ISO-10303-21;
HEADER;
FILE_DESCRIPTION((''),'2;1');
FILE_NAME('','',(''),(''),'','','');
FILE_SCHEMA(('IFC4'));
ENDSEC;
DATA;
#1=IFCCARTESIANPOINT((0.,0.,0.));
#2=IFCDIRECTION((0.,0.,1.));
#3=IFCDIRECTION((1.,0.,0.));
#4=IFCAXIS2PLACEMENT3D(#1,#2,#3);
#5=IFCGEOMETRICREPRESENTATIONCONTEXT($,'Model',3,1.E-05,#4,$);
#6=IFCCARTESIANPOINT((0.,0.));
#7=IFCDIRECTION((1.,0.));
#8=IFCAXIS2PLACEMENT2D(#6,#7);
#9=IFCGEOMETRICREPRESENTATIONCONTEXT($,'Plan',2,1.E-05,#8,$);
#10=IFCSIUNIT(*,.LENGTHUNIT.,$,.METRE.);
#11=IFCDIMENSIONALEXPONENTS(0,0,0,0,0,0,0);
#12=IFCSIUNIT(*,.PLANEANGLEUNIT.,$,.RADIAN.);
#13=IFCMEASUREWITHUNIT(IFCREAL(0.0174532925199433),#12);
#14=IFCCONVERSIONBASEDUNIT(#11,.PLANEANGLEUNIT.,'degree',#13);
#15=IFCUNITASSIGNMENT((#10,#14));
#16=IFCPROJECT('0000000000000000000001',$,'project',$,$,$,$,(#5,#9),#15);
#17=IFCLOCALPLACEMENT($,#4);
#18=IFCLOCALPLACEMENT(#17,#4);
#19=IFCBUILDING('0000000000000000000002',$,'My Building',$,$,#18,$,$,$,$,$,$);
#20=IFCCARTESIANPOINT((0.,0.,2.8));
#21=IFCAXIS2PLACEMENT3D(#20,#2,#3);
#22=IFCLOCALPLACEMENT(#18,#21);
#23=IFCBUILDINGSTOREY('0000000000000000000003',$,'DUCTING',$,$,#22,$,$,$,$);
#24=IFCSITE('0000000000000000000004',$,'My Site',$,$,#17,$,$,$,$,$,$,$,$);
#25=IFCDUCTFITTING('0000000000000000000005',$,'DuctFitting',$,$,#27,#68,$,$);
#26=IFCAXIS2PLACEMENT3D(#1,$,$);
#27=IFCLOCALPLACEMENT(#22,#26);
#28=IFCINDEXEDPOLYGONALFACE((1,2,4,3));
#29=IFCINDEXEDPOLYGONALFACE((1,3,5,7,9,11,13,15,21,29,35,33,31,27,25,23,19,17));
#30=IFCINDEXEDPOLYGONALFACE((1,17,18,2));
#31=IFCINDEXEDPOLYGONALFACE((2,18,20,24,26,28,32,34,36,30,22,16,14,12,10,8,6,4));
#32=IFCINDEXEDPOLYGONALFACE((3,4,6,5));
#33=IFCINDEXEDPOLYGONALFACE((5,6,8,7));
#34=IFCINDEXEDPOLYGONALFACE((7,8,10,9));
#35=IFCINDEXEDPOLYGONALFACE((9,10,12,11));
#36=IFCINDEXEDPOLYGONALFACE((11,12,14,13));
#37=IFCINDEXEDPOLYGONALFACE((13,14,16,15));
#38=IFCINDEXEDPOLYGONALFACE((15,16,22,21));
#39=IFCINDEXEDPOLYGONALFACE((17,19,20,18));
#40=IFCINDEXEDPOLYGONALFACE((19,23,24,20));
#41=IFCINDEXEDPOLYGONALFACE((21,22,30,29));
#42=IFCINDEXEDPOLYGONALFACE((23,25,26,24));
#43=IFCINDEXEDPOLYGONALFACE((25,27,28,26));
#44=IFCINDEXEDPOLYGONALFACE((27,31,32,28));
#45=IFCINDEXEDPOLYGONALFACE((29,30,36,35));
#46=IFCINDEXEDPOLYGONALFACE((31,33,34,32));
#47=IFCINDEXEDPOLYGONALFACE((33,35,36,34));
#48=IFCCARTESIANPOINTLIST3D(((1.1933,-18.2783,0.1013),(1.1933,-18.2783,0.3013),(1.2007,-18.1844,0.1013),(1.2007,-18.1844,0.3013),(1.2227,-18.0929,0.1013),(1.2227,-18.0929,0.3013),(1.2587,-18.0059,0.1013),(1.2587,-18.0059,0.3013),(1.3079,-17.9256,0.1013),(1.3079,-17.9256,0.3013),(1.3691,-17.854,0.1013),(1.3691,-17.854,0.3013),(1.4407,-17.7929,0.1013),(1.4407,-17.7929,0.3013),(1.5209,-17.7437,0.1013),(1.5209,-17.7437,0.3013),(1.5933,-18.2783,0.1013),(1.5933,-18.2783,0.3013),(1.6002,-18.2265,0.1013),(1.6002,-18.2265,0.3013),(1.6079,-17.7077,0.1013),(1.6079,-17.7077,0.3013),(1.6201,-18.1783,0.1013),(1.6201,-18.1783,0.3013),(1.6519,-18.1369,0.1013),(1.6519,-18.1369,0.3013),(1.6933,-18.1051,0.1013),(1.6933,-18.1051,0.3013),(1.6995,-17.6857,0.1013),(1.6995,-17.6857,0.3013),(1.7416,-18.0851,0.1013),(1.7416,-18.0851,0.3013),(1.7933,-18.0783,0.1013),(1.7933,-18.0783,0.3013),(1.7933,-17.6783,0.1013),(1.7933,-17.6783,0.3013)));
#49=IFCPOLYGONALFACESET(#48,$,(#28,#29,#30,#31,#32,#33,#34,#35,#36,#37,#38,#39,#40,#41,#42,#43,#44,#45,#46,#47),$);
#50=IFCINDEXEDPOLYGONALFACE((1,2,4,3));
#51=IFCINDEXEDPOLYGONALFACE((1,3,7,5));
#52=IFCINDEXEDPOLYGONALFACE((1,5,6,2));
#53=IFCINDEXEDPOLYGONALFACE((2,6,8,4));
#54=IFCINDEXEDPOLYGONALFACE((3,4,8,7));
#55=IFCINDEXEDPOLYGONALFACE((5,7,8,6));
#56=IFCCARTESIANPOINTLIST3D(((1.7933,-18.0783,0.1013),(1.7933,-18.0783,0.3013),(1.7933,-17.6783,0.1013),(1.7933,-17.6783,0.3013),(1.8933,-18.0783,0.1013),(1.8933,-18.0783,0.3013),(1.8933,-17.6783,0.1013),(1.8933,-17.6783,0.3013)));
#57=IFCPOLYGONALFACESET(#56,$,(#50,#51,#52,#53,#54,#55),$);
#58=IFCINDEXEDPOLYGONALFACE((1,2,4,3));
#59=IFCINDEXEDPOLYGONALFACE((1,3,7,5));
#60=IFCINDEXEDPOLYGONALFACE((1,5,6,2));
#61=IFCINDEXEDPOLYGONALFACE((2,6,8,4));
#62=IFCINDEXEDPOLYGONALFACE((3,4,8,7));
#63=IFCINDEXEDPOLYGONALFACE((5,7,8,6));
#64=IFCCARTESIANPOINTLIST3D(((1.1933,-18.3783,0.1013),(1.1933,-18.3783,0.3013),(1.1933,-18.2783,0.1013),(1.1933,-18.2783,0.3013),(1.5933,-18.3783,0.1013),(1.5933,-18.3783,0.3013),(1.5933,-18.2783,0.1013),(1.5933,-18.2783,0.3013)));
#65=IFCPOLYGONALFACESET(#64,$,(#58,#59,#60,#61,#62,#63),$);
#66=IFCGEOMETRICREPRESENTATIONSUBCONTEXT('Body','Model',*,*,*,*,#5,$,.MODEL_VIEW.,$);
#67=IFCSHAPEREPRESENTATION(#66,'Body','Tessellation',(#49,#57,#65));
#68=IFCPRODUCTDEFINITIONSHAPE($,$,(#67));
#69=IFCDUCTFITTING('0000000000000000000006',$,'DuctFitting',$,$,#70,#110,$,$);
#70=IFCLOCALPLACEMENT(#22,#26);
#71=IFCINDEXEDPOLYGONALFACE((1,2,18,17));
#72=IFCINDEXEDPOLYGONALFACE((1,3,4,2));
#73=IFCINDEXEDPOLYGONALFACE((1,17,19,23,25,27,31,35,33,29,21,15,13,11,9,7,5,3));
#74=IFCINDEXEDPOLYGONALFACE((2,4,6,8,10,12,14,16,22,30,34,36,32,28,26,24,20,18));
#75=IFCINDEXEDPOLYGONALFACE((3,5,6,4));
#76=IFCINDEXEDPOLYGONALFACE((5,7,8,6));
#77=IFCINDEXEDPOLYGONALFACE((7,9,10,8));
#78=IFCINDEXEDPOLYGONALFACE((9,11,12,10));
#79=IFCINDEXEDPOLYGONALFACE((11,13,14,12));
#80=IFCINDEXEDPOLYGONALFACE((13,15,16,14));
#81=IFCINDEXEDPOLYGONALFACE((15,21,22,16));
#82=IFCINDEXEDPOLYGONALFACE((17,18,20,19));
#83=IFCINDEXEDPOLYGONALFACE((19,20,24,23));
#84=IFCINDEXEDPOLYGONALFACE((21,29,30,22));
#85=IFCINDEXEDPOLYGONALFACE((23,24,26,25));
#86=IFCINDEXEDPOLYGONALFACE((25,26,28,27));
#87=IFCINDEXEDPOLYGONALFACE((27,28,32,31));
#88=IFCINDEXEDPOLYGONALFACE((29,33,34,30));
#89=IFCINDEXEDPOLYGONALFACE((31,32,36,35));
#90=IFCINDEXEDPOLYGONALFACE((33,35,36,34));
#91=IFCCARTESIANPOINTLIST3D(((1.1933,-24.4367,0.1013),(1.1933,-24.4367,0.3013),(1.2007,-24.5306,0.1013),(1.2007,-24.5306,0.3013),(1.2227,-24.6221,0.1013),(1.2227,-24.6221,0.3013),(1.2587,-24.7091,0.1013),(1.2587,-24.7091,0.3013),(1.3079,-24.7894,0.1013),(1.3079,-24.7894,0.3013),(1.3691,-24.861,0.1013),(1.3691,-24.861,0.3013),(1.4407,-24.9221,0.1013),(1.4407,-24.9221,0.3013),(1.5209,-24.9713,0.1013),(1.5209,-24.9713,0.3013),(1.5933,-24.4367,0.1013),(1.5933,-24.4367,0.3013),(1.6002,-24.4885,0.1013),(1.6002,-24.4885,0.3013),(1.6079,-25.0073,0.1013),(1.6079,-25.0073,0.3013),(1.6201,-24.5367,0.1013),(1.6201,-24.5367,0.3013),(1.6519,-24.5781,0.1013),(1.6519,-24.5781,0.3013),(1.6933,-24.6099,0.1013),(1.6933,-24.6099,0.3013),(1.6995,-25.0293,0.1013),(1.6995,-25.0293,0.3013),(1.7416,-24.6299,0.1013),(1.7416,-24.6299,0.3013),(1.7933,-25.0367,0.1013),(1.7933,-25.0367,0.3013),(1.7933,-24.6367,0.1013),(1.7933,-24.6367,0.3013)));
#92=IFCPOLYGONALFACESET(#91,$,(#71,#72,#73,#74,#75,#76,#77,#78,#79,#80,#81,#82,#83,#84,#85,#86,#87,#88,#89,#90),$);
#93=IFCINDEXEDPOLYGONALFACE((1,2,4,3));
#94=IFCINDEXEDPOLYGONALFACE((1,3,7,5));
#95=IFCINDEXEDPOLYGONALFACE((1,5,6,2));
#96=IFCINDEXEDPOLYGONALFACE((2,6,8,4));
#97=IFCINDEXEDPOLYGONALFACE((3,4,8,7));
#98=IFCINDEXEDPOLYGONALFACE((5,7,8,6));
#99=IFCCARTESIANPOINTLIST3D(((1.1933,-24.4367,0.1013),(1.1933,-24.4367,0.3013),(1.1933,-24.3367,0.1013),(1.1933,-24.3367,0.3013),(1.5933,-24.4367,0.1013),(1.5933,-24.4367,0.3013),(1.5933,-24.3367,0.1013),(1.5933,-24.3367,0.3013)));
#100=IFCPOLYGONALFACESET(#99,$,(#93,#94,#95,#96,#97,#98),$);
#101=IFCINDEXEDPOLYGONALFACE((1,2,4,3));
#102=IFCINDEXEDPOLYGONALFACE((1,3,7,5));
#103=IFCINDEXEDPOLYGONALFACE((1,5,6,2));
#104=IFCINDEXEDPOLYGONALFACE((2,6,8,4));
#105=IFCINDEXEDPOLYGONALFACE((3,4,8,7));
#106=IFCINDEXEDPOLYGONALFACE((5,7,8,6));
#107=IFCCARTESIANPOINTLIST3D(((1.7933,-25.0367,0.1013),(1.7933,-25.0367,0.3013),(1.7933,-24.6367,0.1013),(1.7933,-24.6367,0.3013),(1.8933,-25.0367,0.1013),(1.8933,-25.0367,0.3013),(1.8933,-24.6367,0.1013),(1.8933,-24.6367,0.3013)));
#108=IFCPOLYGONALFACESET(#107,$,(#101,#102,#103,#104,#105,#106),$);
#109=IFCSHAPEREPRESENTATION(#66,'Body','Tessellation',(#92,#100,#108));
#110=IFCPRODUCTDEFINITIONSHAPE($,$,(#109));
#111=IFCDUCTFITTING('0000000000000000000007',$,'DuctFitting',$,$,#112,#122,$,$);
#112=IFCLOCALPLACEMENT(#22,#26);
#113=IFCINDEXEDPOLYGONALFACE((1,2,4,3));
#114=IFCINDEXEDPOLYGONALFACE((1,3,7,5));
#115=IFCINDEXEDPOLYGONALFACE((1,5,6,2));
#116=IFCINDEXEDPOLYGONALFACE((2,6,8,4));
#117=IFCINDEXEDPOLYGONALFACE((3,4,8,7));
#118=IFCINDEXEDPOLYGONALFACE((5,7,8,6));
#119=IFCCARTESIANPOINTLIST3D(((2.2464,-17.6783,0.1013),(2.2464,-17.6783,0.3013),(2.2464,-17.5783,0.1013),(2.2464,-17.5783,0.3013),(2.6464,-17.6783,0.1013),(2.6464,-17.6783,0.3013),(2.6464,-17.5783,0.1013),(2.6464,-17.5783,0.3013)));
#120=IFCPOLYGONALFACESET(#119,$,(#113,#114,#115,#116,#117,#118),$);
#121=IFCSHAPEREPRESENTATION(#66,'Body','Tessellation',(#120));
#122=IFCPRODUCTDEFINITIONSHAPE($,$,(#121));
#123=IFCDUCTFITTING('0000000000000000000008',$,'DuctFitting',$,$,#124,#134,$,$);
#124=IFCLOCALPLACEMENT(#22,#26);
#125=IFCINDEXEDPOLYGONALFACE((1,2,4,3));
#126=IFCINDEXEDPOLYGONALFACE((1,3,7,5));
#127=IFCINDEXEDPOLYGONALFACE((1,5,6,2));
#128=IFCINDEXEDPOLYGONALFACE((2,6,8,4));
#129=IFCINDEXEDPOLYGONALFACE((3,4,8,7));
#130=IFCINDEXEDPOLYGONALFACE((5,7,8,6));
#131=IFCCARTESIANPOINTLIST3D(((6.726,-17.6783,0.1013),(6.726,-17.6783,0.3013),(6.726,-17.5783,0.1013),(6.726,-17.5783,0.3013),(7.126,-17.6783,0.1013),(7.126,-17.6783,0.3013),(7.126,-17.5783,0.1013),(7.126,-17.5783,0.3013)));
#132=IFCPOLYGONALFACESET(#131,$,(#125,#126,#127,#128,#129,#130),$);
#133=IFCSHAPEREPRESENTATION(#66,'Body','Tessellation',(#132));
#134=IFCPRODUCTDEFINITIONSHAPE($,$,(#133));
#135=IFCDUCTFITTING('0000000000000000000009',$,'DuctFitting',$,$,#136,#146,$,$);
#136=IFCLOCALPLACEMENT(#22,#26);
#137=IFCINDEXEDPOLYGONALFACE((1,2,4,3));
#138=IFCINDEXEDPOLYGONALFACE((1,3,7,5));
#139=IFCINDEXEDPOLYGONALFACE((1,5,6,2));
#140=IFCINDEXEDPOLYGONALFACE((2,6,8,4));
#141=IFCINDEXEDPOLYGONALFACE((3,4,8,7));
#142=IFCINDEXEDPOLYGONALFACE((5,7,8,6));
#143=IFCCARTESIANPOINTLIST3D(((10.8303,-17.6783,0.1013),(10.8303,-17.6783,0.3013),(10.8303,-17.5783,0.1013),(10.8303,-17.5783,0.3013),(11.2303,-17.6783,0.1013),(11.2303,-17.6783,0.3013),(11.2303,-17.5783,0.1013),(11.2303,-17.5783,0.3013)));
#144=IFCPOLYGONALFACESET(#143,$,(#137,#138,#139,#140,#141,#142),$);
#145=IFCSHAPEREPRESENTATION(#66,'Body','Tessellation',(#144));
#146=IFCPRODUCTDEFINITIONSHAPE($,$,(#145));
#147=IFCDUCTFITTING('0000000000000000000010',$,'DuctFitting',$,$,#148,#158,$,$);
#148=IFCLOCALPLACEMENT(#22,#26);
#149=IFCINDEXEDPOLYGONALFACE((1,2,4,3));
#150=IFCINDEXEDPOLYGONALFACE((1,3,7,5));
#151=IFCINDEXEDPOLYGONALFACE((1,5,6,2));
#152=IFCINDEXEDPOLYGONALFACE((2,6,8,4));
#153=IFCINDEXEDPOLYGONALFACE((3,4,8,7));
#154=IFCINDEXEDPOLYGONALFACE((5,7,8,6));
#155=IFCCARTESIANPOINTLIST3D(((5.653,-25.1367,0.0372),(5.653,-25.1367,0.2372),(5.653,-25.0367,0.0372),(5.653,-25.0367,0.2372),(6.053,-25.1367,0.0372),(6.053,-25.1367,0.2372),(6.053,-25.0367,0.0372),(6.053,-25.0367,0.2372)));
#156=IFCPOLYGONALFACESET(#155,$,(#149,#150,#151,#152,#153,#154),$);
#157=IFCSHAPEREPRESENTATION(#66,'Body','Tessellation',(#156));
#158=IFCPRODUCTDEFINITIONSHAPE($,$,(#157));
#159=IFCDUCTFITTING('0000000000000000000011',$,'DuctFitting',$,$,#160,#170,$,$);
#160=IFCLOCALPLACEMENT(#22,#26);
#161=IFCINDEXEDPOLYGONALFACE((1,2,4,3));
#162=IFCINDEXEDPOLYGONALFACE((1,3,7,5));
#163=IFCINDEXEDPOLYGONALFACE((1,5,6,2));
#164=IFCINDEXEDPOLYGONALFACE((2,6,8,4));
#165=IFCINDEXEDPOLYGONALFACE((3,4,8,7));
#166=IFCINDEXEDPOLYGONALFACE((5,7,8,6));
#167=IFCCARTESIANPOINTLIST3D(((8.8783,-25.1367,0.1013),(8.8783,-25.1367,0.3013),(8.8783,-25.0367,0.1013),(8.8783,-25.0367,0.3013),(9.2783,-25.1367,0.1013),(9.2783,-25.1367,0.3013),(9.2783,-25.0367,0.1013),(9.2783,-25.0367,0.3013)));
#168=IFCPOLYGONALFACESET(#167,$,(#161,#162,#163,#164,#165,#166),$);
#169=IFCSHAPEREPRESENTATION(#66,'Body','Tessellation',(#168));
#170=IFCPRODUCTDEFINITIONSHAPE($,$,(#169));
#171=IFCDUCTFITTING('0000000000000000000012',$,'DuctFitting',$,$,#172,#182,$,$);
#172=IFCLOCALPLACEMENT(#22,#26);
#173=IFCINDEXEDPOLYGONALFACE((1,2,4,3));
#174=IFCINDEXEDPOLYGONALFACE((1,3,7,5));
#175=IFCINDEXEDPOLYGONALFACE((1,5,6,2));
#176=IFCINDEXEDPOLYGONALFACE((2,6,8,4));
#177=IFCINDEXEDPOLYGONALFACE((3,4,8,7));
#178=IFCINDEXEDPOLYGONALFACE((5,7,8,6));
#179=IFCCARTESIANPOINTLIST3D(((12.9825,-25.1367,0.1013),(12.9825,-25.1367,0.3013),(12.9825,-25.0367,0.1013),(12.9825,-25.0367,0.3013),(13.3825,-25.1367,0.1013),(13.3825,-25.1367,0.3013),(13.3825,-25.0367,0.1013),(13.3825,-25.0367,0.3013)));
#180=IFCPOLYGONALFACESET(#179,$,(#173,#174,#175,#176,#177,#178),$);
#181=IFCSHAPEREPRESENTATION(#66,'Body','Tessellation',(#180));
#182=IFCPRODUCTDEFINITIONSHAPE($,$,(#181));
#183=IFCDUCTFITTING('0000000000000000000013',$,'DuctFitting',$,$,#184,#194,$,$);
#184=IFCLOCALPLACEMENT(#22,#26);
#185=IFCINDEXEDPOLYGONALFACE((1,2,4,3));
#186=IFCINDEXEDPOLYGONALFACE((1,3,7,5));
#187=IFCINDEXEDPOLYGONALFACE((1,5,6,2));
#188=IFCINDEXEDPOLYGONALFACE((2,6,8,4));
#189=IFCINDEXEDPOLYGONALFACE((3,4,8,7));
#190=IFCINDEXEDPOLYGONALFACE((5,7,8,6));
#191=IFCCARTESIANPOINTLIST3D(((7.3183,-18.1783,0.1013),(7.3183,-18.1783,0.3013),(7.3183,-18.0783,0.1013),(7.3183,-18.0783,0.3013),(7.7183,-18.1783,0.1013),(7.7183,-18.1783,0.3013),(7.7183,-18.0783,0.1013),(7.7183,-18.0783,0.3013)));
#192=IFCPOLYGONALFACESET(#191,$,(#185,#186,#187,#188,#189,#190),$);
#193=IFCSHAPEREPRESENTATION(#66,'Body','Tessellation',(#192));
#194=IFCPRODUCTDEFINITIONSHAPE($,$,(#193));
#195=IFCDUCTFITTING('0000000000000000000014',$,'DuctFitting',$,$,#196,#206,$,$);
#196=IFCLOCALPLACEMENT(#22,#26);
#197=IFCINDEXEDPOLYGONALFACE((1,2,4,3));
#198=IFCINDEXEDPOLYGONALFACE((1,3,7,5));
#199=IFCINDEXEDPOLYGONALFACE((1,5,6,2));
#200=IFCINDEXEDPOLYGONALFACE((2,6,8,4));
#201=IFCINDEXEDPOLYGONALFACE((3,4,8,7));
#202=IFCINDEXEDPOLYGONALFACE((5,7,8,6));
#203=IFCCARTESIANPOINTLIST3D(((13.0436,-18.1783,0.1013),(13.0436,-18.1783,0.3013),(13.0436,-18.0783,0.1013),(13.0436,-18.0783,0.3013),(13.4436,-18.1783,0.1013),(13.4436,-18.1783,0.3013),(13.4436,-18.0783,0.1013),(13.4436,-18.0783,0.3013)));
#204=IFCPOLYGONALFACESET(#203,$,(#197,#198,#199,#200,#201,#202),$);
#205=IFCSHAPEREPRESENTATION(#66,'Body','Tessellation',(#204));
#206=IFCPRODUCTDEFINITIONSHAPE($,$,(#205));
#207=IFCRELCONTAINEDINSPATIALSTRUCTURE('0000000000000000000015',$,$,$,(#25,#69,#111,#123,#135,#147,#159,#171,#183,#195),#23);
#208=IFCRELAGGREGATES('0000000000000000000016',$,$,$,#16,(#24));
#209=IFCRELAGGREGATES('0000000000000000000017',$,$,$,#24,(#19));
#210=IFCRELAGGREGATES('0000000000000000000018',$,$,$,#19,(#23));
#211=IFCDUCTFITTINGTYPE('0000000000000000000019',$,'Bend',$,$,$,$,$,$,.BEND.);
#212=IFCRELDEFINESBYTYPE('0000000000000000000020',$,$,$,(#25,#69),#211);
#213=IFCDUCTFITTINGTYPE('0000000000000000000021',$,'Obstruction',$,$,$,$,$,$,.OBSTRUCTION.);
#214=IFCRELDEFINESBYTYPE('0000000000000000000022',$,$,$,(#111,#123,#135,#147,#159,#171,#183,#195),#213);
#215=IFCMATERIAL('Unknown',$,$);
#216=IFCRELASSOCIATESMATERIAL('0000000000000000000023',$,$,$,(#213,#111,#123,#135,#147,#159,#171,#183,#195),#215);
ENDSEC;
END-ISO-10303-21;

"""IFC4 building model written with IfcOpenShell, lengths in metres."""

from ifc_helpers import new_model, entity, si_unit, converted_unit, frame, origin_with_axes, origin_2d_with_axis, place, context, subcontext, project, spatial, line, arc, indexed_curve, rectangle, outline, extrude, source, transform, mapped, material, material_profile, profile_set, profile_usage, type_object, type_shapes, element, save


model = new_model("IFC4")

# Units and contexts
model_context = context("Model", 3, precision=1e-05, world=origin_with_axes())
plan_context = context("Plan", 2, precision=1e-05, world=origin_2d_with_axis())
body_context = subcontext(model_context, "Body", "Model", "MODEL_VIEW")
ifc_project = project(units=[si_unit("LENGTHUNIT", "METRE"), converted_unit("PLANEANGLEUNIT", "degree", entity("IfcReal", 0.0174532925199433), si_unit("PLANEANGLEUNIT", "RADIAN"), dimensions=[0, 0, 0, 0, 0, 0, 0])], contexts=[model_context, plan_context])

# Site, building, storey
site_placement = place(None, origin_with_axes())
site = spatial("IfcSite", under=ifc_project, at=site_placement, Name="My Site")
building_placement = place(site_placement, origin_with_axes())
building = spatial("IfcBuilding", under=site, at=building_placement, Name="My Building")
storey_placement = place(building_placement, frame((0.0, 0.0, 2.8), z_axis=(0.0, 0.0, 1.0), x_axis=(1.0, 0.0, 0.0)))
storey = spatial("IfcBuildingStorey", under=building, at=storey_placement, Name="DUCTING")

# Shared definitions
ifc_material = material(Name="Unknown")

# Duct fittings
duct_fitting_type_1 = type_object("IfcDuctFittingType", Name="Bend", PredefinedType="BEND")
shared_shape = source(origin_with_axes(), body_context, "Body", "SweptSolid", [
    extrude(outline(indexed_curve([(-0.2, 0.0), (-0.2586, -0.1414), (-0.4, -0.2), (-0.4, -0.6), (0.0243, -0.4243), (0.2, 0.0)], segments=[arc(1, 2, 3), line(3, 4), arc(4, 5, 6), line(6, 1)])), frame((0.0, -0.1, -0.1), z_axis=(0.0, -1.0, 0.0), x_axis=(1.0, 0.0, 0.0)), (0.0, 0.0, -1.0), 0.2),
    extrude(rectangle(XDim=0.4, YDim=0.2), origin_with_axes(), (0.0, 0.0, -1.0), 0.1),
    extrude(rectangle(XDim=0.4, YDim=0.2), frame((-0.4, 0.0, -0.5), z_axis=(-1.0, 0.0, 0.000001), x_axis=(-0.000001, 0.0, -1.0)), (0.0, 0.0, 1.0), 0.1),
])
type_shapes(duct_fitting_type_1, [shared_shape])
for number, where, z_axis, x_axis, name in (
    (1, (1.8933, -17.8783, 0.2013), (1.0, -0.000001, 0.000001), (0.000001, 1.0, 0.0), "DuctFitting"),
    (2, (1.3933, -24.3367, 0.2013), (0.0, 1.0, 0.0), (-1.0, 0.0, 0.0), "DuctFitting"),
):
    element("IfcDuctFitting", number, at=place(storey_placement, frame(where, z_axis=z_axis, x_axis=x_axis)), inside=storey, type_object=duct_fitting_type_1, Name=name, context=body_context, shape_type="MappedRepresentation", body=[
        mapped(shared_shape, transform((0.0, 0.0, 0.0), x_axis=(1.0, 0.0, 0.0), y_axis=(0.0, 1.0, 0.0), z_axis=(0.0, 0.0, 1.0), scale=1.0)),
    ])
ifc_material_profile_1 = material_profile(ifc_material, rectangle(XDim=0.4, YDim=0.2))
ifc_profile_set_1 = profile_set([ifc_material_profile_1])
ifc_profile_usage_1 = profile_usage(ifc_profile_set_1, cardinal=5)
duct_fitting_type_2 = type_object("IfcDuctFittingType", Name="Obstruction", PredefinedType="OBSTRUCTION", material=ifc_profile_set_1)
duct_fitting_1_placement = place(storey_placement, frame((2.4464, -17.6783, 0.2013), z_axis=(0.0, 1.0, 0.0), x_axis=(-1.0, 0.0, 0.0)))
element("IfcDuctFitting", 3, at=duct_fitting_1_placement, inside=storey, type_object=duct_fitting_type_2, material=ifc_profile_usage_1, Name="DuctFitting", context=body_context, shape_type="SweptSolid", body=[
    extrude(rectangle(XDim=0.4, YDim=0.2), origin_with_axes(), (0.0, 0.0, 1.0), 0.1),
])
ifc_profile_usage_2 = profile_usage(ifc_profile_set_1, cardinal=5)
duct_fitting_2_placement = place(storey_placement, frame((6.926, -17.6783, 0.2013), z_axis=(0.0, 1.0, 0.0), x_axis=(-1.0, 0.0, 0.0)))
element("IfcDuctFitting", 4, at=duct_fitting_2_placement, inside=storey, type_object=duct_fitting_type_2, material=ifc_profile_usage_2, Name="DuctFitting", context=body_context, shape_type="SweptSolid", body=[
    extrude(rectangle(XDim=0.4, YDim=0.2), origin_with_axes(), (0.0, 0.0, 1.0), 0.1),
])
ifc_profile_usage_3 = profile_usage(ifc_profile_set_1, cardinal=5)
duct_fitting_3_placement = place(storey_placement, frame((11.0303, -17.6783, 0.2013), z_axis=(0.0, 1.0, 0.0), x_axis=(-1.0, 0.0, 0.0)))
element("IfcDuctFitting", 5, at=duct_fitting_3_placement, inside=storey, type_object=duct_fitting_type_2, material=ifc_profile_usage_3, Name="DuctFitting", context=body_context, shape_type="SweptSolid", body=[
    extrude(rectangle(XDim=0.4, YDim=0.2), origin_with_axes(), (0.0, 0.0, 1.0), 0.1),
])
ifc_profile_usage_4 = profile_usage(ifc_profile_set_1, cardinal=5)
duct_fitting_4_placement = place(storey_placement, frame((5.853, -25.0367, 0.1372), z_axis=(0.0, -1.0, 0.0), x_axis=(1.0, 0.0, 0.0)))
element("IfcDuctFitting", 6, at=duct_fitting_4_placement, inside=storey, type_object=duct_fitting_type_2, material=ifc_profile_usage_4, Name="DuctFitting", context=body_context, shape_type="SweptSolid", body=[
    extrude(rectangle(XDim=0.4, YDim=0.2), origin_with_axes(), (0.0, 0.0, 1.0), 0.1),
])
ifc_profile_usage_5 = profile_usage(ifc_profile_set_1, cardinal=5)
duct_fitting_5_placement = place(storey_placement, frame((9.0783, -25.0367, 0.2013), z_axis=(0.0, -1.0, 0.0), x_axis=(1.0, 0.0, 0.0)))
element("IfcDuctFitting", 7, at=duct_fitting_5_placement, inside=storey, type_object=duct_fitting_type_2, material=ifc_profile_usage_5, Name="DuctFitting", context=body_context, shape_type="SweptSolid", body=[
    extrude(rectangle(XDim=0.4, YDim=0.2), origin_with_axes(), (0.0, 0.0, 1.0), 0.1),
])
ifc_profile_usage_6 = profile_usage(ifc_profile_set_1, cardinal=5)
duct_fitting_6_placement = place(storey_placement, frame((13.1825, -25.0367, 0.2013), z_axis=(0.0, -1.0, 0.0), x_axis=(1.0, 0.0, 0.0)))
element("IfcDuctFitting", 8, at=duct_fitting_6_placement, inside=storey, type_object=duct_fitting_type_2, material=ifc_profile_usage_6, Name="DuctFitting", context=body_context, shape_type="SweptSolid", body=[
    extrude(rectangle(XDim=0.4, YDim=0.2), origin_with_axes(), (0.0, 0.0, 1.0), 0.1),
])
ifc_profile_usage_7 = profile_usage(ifc_profile_set_1, cardinal=5)
duct_fitting_7_placement = place(storey_placement, frame((7.5183, -18.0783, 0.2013), z_axis=(0.0, -1.0, 0.0), x_axis=(1.0, 0.0, 0.0)))
element("IfcDuctFitting", 9, at=duct_fitting_7_placement, inside=storey, type_object=duct_fitting_type_2, material=ifc_profile_usage_7, Name="DuctFitting", context=body_context, shape_type="SweptSolid", body=[
    extrude(rectangle(XDim=0.4, YDim=0.2), origin_with_axes(), (0.0, 0.0, 1.0), 0.1),
])
ifc_profile_usage_8 = profile_usage(ifc_profile_set_1, cardinal=5)
duct_fitting_8_placement = place(storey_placement, frame((13.2436, -18.0783, 0.2013), z_axis=(0.0, -1.0, 0.0), x_axis=(1.0, 0.0, 0.0)))
element("IfcDuctFitting", 10, at=duct_fitting_8_placement, inside=storey, type_object=duct_fitting_type_2, material=ifc_profile_usage_8, Name="DuctFitting", context=body_context, shape_type="SweptSolid", body=[
    extrude(rectangle(XDim=0.4, YDim=0.2), origin_with_axes(), (0.0, 0.0, 1.0), 0.1),
])

save(model, "model.ifc")
